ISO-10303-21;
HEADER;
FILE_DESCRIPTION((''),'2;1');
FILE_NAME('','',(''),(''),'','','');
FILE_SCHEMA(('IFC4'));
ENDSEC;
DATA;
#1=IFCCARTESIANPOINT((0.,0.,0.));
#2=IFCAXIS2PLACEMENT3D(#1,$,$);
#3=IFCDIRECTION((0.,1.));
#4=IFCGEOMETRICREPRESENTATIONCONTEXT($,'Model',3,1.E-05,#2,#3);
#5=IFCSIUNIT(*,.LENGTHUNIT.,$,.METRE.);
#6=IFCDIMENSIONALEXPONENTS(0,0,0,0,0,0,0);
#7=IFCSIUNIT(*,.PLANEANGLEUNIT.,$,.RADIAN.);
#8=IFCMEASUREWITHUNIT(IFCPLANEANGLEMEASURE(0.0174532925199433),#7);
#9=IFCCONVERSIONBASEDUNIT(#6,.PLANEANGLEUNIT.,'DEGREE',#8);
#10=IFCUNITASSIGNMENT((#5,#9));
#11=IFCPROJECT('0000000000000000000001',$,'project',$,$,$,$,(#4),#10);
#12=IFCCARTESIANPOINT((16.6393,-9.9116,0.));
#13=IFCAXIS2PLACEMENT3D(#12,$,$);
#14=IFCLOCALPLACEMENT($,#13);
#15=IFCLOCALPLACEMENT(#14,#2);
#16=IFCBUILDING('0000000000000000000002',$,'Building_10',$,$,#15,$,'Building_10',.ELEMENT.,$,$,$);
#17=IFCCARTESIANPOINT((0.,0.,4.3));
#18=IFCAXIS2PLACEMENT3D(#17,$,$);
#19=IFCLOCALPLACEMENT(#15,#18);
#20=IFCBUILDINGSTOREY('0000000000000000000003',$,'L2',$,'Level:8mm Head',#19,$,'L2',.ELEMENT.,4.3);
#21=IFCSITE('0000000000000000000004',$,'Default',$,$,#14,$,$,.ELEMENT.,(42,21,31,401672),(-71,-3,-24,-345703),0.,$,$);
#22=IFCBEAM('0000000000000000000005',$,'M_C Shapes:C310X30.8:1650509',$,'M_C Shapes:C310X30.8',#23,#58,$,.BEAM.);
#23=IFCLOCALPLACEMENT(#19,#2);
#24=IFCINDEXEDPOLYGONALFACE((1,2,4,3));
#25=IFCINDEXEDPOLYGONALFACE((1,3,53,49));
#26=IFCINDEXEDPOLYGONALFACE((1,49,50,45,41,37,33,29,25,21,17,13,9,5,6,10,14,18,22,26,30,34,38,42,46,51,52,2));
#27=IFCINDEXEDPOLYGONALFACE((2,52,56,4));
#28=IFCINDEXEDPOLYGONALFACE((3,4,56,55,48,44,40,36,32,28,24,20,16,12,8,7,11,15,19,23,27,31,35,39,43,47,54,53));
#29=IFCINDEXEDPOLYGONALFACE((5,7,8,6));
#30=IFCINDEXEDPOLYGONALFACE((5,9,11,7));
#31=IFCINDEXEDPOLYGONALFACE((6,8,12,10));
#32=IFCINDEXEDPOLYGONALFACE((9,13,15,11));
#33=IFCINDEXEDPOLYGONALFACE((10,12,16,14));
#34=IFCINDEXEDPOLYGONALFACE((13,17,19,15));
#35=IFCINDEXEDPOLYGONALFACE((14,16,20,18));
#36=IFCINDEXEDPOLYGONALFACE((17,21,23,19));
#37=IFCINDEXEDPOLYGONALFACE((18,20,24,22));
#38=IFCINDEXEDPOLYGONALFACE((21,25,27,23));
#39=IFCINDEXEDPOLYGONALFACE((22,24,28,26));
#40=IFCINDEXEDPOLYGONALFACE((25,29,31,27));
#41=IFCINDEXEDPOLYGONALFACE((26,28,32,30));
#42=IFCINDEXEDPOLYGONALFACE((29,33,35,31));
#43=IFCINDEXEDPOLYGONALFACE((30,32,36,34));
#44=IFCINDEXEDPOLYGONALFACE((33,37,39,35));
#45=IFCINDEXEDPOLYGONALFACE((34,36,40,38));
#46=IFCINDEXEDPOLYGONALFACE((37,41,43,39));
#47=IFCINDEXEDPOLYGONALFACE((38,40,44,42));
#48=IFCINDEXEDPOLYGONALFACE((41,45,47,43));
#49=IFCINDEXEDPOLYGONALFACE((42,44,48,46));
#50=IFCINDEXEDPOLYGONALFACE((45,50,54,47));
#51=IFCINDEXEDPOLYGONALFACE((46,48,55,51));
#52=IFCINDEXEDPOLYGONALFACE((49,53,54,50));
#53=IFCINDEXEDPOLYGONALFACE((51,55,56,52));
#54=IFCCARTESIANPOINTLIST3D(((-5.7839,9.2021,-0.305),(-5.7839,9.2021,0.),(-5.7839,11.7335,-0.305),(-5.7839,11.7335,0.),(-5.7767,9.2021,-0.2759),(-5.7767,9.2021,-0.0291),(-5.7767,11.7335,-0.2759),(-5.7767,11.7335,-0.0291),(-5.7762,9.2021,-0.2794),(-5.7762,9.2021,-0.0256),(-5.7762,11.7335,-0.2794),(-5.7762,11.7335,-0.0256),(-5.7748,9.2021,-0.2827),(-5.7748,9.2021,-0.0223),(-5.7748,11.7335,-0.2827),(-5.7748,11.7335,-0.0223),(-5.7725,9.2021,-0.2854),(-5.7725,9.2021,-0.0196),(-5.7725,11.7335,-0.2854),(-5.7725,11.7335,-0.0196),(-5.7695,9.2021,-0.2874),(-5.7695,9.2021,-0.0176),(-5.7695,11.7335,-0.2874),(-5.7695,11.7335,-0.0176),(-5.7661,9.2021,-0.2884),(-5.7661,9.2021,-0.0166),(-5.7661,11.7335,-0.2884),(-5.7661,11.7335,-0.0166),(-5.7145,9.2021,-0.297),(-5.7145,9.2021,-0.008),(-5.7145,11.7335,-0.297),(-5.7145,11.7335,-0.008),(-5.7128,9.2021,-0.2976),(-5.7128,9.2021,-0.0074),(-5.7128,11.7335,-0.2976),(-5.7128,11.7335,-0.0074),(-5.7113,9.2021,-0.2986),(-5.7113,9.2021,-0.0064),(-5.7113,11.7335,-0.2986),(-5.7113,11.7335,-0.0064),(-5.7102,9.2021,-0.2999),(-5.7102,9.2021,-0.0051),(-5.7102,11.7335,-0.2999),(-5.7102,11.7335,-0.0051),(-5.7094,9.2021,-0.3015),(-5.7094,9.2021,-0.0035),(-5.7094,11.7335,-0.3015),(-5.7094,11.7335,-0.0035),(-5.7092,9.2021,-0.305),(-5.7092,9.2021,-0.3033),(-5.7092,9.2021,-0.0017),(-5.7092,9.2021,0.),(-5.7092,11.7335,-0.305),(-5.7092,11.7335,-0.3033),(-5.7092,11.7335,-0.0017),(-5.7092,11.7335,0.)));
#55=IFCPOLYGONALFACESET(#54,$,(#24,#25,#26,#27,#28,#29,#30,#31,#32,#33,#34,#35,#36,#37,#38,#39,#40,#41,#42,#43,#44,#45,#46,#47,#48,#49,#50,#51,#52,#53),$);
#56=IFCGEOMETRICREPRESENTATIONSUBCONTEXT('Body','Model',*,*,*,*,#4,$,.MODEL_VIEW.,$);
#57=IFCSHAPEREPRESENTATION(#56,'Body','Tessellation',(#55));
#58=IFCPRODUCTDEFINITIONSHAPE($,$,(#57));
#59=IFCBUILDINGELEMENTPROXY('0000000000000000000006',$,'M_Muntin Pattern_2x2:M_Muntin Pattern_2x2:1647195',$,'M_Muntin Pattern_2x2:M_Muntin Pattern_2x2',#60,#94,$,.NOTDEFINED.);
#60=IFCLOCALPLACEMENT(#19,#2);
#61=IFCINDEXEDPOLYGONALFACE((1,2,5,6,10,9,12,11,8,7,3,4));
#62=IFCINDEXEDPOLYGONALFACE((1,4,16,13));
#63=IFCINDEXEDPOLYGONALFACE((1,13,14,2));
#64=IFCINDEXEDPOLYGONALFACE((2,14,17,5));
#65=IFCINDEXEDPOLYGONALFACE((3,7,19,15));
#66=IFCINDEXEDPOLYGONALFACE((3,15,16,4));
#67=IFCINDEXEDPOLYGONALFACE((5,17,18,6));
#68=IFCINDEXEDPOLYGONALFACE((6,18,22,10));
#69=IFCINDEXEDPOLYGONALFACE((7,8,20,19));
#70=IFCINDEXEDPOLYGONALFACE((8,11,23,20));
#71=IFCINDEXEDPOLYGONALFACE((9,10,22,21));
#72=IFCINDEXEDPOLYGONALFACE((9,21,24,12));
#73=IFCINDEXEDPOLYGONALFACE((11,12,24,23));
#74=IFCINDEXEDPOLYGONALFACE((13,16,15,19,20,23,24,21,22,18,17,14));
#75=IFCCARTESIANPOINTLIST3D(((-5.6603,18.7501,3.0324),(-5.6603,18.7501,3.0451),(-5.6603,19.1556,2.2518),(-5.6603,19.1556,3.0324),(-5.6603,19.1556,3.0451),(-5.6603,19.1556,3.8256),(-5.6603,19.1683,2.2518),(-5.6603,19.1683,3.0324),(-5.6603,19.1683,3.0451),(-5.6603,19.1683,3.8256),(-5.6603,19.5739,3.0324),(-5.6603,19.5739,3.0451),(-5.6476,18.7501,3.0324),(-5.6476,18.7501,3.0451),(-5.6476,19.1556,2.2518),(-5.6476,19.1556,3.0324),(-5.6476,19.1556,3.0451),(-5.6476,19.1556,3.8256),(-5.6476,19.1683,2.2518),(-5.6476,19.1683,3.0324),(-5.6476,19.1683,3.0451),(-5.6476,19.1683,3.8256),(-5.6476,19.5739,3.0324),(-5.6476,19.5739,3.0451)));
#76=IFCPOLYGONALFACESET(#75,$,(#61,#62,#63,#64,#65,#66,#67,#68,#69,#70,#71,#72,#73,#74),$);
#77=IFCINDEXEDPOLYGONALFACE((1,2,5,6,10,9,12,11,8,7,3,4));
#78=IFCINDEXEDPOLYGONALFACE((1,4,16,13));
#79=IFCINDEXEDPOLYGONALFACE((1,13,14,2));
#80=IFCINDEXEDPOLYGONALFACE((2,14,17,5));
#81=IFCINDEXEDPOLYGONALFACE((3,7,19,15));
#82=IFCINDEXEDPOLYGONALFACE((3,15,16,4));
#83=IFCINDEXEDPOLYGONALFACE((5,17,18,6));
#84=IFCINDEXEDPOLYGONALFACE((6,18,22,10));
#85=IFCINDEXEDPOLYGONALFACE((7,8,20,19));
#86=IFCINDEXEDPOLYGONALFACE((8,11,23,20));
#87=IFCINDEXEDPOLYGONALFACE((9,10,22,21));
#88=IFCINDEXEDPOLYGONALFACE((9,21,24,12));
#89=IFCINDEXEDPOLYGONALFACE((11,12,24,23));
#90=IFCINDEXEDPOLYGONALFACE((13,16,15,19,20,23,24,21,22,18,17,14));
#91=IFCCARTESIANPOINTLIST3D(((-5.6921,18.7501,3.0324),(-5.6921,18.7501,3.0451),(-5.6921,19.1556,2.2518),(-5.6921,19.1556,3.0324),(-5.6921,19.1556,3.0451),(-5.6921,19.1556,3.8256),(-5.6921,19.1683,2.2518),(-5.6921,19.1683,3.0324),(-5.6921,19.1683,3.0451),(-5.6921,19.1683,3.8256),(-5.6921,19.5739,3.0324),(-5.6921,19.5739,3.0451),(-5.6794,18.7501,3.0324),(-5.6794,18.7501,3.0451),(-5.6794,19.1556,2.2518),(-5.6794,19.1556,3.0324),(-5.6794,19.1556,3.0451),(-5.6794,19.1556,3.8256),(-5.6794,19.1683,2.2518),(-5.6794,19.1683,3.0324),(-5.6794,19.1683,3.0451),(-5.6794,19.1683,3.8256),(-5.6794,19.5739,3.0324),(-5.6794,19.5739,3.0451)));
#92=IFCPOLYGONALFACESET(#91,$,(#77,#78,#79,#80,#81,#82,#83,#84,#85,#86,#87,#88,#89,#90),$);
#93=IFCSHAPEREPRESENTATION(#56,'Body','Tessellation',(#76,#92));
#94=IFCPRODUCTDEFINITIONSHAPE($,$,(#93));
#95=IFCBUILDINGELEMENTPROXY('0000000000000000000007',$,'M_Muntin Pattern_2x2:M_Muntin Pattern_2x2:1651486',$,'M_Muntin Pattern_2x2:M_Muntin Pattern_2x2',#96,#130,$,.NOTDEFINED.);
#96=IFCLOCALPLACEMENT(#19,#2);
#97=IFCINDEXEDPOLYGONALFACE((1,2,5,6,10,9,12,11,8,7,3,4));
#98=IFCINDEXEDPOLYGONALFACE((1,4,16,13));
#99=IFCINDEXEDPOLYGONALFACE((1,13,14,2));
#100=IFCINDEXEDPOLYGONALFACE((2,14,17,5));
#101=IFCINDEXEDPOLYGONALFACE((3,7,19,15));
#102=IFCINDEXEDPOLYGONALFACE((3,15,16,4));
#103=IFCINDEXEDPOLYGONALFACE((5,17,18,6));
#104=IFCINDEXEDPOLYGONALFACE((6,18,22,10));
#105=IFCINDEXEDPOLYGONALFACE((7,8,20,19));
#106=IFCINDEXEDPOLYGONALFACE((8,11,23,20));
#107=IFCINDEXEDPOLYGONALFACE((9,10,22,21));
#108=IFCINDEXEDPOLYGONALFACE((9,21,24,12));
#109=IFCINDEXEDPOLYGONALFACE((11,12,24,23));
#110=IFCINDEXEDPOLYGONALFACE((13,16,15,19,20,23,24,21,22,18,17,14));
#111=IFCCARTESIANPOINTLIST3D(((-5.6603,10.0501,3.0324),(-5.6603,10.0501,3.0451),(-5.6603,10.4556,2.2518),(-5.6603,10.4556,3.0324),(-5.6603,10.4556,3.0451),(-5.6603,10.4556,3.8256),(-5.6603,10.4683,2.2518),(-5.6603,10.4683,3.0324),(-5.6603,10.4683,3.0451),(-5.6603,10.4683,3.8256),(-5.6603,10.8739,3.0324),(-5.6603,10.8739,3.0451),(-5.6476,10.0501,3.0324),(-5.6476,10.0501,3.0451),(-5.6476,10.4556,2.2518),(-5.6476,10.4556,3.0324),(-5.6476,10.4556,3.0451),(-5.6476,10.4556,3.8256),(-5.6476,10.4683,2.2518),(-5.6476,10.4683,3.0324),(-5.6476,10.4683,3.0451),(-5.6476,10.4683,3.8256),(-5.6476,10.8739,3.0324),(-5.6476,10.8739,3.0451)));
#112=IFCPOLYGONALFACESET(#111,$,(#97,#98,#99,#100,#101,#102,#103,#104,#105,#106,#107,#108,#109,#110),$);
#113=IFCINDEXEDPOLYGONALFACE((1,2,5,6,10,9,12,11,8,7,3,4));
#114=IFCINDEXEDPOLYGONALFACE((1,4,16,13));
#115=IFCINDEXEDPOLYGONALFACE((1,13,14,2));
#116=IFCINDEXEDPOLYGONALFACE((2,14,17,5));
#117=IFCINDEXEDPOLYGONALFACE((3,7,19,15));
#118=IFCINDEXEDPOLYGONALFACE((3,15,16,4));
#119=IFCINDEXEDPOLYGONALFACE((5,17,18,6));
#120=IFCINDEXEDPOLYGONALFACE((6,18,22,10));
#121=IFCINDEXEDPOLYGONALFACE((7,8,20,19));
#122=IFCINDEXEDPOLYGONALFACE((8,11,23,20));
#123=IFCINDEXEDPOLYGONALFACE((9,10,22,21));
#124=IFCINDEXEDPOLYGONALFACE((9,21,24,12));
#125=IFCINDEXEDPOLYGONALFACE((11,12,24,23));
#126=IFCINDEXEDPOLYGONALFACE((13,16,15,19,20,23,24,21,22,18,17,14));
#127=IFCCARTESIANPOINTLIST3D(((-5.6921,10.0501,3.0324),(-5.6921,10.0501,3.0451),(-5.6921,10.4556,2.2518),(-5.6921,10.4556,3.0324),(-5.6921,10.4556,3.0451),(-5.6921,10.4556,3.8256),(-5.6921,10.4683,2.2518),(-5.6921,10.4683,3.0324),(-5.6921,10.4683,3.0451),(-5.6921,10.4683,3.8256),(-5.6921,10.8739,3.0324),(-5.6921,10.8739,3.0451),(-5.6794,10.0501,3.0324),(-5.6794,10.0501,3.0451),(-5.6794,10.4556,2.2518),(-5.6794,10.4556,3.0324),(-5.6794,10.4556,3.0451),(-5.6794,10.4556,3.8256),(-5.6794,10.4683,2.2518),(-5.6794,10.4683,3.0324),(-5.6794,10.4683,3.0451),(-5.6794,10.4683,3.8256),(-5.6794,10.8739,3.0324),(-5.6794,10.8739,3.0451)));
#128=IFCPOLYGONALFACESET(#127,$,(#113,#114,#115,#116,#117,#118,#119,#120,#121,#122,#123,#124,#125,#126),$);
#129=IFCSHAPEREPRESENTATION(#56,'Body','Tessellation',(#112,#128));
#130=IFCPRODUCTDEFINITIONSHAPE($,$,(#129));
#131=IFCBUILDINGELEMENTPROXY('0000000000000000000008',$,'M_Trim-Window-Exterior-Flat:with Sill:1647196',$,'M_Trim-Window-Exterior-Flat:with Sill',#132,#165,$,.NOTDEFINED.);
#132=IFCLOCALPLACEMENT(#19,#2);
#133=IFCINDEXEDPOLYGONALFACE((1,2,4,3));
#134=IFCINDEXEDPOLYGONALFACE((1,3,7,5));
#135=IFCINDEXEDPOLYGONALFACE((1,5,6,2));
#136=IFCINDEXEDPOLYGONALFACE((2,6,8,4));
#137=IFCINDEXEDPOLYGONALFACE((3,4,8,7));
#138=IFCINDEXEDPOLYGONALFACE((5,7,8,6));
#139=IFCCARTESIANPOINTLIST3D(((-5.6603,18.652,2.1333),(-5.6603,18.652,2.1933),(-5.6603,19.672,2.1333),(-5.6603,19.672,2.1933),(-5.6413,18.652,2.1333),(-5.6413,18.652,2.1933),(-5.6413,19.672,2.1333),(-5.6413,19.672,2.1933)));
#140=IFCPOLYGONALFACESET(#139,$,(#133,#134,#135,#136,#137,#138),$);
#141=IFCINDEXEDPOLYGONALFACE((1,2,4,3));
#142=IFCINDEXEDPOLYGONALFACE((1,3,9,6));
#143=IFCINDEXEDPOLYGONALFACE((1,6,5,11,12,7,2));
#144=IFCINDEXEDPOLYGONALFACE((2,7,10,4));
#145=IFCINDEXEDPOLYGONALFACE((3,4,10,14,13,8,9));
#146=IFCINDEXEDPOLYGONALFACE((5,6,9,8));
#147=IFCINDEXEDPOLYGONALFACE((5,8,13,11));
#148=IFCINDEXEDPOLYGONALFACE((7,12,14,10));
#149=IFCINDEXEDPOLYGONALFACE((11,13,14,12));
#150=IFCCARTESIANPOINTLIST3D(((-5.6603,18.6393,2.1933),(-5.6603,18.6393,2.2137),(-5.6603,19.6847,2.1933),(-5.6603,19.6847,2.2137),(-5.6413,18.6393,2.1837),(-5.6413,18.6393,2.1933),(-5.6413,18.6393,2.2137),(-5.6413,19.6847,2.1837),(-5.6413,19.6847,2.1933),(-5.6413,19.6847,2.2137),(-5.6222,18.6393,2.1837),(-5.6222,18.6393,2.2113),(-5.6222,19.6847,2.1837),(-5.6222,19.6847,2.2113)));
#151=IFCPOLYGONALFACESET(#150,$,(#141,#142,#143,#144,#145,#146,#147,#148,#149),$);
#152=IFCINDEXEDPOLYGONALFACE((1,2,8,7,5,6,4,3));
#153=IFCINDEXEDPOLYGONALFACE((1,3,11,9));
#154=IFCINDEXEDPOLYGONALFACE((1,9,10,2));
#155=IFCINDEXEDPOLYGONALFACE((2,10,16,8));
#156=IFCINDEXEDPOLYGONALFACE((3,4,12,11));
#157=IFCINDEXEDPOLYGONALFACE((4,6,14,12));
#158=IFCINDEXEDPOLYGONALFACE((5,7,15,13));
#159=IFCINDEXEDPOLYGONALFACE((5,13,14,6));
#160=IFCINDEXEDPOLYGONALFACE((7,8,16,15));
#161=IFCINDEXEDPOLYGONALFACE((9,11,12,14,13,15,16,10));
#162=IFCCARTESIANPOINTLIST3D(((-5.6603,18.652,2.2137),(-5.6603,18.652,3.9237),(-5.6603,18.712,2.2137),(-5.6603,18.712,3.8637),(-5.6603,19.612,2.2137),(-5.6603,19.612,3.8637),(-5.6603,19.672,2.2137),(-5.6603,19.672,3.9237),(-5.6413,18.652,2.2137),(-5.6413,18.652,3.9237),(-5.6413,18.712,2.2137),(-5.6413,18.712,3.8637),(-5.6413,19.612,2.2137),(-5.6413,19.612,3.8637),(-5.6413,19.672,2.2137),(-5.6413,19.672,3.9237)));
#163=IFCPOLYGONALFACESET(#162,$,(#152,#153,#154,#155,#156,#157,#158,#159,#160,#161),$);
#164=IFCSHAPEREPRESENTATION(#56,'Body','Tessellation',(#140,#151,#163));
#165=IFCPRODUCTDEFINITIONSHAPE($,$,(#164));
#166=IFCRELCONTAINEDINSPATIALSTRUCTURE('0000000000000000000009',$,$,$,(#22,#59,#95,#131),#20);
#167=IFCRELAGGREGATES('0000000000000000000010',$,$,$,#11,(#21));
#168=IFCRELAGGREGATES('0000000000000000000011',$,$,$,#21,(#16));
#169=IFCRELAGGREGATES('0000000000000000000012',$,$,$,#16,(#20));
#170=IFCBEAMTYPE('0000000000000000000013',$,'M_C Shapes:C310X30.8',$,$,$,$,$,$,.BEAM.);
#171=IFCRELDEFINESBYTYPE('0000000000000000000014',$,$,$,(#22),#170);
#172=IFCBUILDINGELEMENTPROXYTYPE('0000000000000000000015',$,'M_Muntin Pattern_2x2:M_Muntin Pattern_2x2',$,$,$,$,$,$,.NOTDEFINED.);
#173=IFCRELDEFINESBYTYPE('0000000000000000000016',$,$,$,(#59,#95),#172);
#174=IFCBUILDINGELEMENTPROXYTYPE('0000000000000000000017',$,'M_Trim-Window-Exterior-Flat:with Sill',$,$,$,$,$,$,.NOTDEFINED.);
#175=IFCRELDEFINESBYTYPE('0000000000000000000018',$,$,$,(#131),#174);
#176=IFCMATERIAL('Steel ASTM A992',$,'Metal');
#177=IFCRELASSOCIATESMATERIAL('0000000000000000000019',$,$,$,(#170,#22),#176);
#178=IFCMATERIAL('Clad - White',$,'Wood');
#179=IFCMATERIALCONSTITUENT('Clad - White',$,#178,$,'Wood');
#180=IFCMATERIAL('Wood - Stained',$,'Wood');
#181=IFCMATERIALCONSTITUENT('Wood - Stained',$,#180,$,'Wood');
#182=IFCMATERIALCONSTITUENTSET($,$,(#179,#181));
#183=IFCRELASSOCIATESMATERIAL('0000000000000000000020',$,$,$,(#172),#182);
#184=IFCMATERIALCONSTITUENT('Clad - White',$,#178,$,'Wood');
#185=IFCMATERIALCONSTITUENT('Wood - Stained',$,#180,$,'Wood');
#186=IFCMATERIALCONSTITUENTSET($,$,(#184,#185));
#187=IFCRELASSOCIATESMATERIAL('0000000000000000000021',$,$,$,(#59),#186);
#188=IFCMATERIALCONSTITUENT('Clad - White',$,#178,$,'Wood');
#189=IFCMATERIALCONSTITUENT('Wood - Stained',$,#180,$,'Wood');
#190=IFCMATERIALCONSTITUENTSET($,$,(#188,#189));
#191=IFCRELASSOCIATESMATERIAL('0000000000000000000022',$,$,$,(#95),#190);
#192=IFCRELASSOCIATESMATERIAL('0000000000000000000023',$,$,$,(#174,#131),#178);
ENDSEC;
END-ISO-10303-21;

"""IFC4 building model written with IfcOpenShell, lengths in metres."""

from ifc_helpers import new_model, entity, si_unit, converted_unit, direction, frame, origin, place, context, subcontext, project, spatial, line, arc, indexed_curve, outline, extrude, source, transform, mapped, material, constituent, constituent_set, type_object, type_shapes, element, save


model = new_model("IFC4")

# Units and contexts
model_context = context("Model", 3, precision=1e-05, world=origin(), true_north=direction((0.0, 1.0)))
body_context = subcontext(model_context, "Body", "Model", "MODEL_VIEW")
ifc_project = project(units=[si_unit("LENGTHUNIT", "METRE"), converted_unit("PLANEANGLEUNIT", "DEGREE", entity("IfcPlaneAngleMeasure", 0.0174532925199433), si_unit("PLANEANGLEUNIT", "RADIAN"), dimensions=[0, 0, 0, 0, 0, 0, 0])], contexts=[model_context])

# Site, building, storey
site_placement = place(None, frame((16.6393, -9.9116, 0.0)))
site = spatial("IfcSite", under=ifc_project, at=site_placement, Name="Default", CompositionType="ELEMENT", RefLatitude=(42, 21, 31, 401672), RefLongitude=(-71, -3, -24, -345703), RefElevation=0.0)
building_placement = place(site_placement, origin())
building = spatial("IfcBuilding", under=site, at=building_placement, Name="Building_10", LongName="Building_10", CompositionType="ELEMENT")
storey_placement = place(building_placement, frame((0.0, 0.0, 4.3)))
storey = spatial("IfcBuildingStorey", under=building, at=storey_placement, Name="L2", ObjectType="Level:8mm Head", LongName="L2", CompositionType="ELEMENT", Elevation=4.3)

# Shared definitions
ifc_material_1 = material(Name="Steel ASTM A992", Category="Metal")

# Beam
beam_type_1 = type_object("IfcBeamType", Name="M_C Shapes:C310X30.8", PredefinedType="BEAM", material=ifc_material_1)
shared_shape_1 = source(origin(), body_context, "Body", "SweptSolid", [
    extrude(outline(indexed_curve([(-0.0406, -0.1525), (0.0341, -0.1525), (0.0341, -0.1508), (0.0326, -0.1467), (0.0288, -0.1445), (-0.0228, -0.1359), (-0.0305, -0.1316), (-0.0335, -0.1234), (-0.0335, 0.1234), (-0.0305, 0.1316), (-0.0228, 0.1359), (0.0288, 0.1445), (0.0326, 0.1467), (0.0341, 0.1508), (0.0341, 0.1525), (-0.0406, 0.1525)], segments=[line(1, 2, 3), arc(3, 4, 5), line(5, 6), arc(6, 7, 8), line(8, 9), arc(9, 10, 11), line(11, 12), arc(12, 13, 14), line(14, 15, 16, 1)], self_intersect=False)), frame((-1.2657, -0.0229, 0.0), z_axis=(1.0, 0.0, 0.0), x_axis=(0.0, -1.0, 0.0)), (0.0, 0.0, 1.0), 2.5314),
])
type_shapes(beam_type_1, [shared_shape_1])
for number, where, z_axis, x_axis, name in (
    (1, (-5.7662, 10.4678, -0.1525), (0.0, 0.0, 1.0), (0.0, 1.0, 0.0), "M_C Shapes:C310X30.8:1650509"),
):
    element("IfcBeam", number, at=place(storey_placement, frame(where, z_axis=z_axis, x_axis=x_axis)), inside=storey, type_object=beam_type_1, material=ifc_material_1, Name=name, ObjectType="M_C Shapes:C310X30.8", PredefinedType="BEAM", context=body_context, shape_type="MappedRepresentation", body=[
        mapped(shared_shape_1, transform((0.0, 0.0, 0.0), scale=1.0)),
    ])

# Building element proxies
ifc_material_2 = material(Name="Clad - White", Category="Wood")
ifc_constituent_1 = constituent(ifc_material_2, Name="Clad - White", Category="Wood")
ifc_material_3 = material(Name="Wood - Stained", Category="Wood")
ifc_constituent_2 = constituent(ifc_material_3, Name="Wood - Stained", Category="Wood")
ifc_constituent_set_1 = constituent_set(constituents=[ifc_constituent_1, ifc_constituent_2])
ifc_constituent_3 = constituent(ifc_material_2, Name="Clad - White", Category="Wood")
ifc_constituent_4 = constituent(ifc_material_3, Name="Wood - Stained", Category="Wood")
ifc_constituent_set_2 = constituent_set(constituents=[ifc_constituent_3, ifc_constituent_4])
building_element_proxy_type_1 = type_object("IfcBuildingElementProxyType", Name="M_Muntin Pattern_2x2:M_Muntin Pattern_2x2", PredefinedType="NOTDEFINED", material=ifc_constituent_set_2)
shared_shape_2 = source(origin(), body_context, "Body", "SweptSolid", [
    extrude(outline(indexed_curve([(0.0064, -0.0064), (0.7869, -0.0064), (0.7869, 0.0063), (0.0064, 0.0063), (0.0064, 0.4119), (-0.0063, 0.4119), (-0.0063, 0.0063), (-0.7869, 0.0063), (-0.7869, -0.0064), (-0.0063, -0.0064), (-0.0063, -0.4119), (0.0064, -0.4119), (0.0064, -0.0064)], self_intersect=False)), frame((0.0, -0.0222, 0.7869), z_axis=(0.0, 1.0, 0.0), x_axis=(0.0, 0.0, 1.0)), (0.0, 0.0, 1.0), 0.0127),
    extrude(outline(indexed_curve([(0.0064, -0.0064), (0.7869, -0.0064), (0.7869, 0.0063), (0.0064, 0.0063), (0.0064, 0.4119), (-0.0063, 0.4119), (-0.0063, 0.0063), (-0.7869, 0.0063), (-0.7869, -0.0064), (-0.0063, -0.0064), (-0.0063, -0.4119), (0.0064, -0.4119), (0.0064, -0.0064)], self_intersect=False)), frame((0.0, 0.0095, 0.7869), z_axis=(0.0, 1.0, 0.0), x_axis=(0.0, 0.0, 1.0)), (0.0, 0.0, 1.0), 0.0127),
])
type_shapes(building_element_proxy_type_1, [shared_shape_2])
proxy_1_placement = place(storey_placement, frame((-5.6698, 19.162, 2.2518), z_axis=(0.0, 0.0, 1.0), x_axis=(0.0, 1.0, 0.0)))
element("IfcBuildingElementProxy", 2, at=proxy_1_placement, inside=storey, type_object=building_element_proxy_type_1, material=ifc_constituent_set_1, Name="M_Muntin Pattern_2x2:M_Muntin Pattern_2x2:1647195", ObjectType="M_Muntin Pattern_2x2:M_Muntin Pattern_2x2", PredefinedType="NOTDEFINED", context=body_context, shape_type="MappedRepresentation", body=[
    mapped(shared_shape_2, transform((0.0, 0.0, 0.0), scale=1.0)),
])
ifc_constituent_5 = constituent(ifc_material_2, Name="Clad - White", Category="Wood")
ifc_constituent_6 = constituent(ifc_material_3, Name="Wood - Stained", Category="Wood")
ifc_constituent_set_3 = constituent_set(constituents=[ifc_constituent_5, ifc_constituent_6])
proxy_2_placement = place(storey_placement, frame((-5.6698, 10.462, 2.2518), z_axis=(0.0, 0.0, 1.0), x_axis=(0.0, 1.0, 0.0)))
element("IfcBuildingElementProxy", 3, at=proxy_2_placement, inside=storey, type_object=building_element_proxy_type_1, material=ifc_constituent_set_3, Name="M_Muntin Pattern_2x2:M_Muntin Pattern_2x2:1651486", ObjectType="M_Muntin Pattern_2x2:M_Muntin Pattern_2x2", PredefinedType="NOTDEFINED", context=body_context, shape_type="MappedRepresentation", body=[
    mapped(shared_shape_2, transform((0.0, 0.0, 0.0), scale=1.0)),
])
building_element_proxy_type_2 = type_object("IfcBuildingElementProxyType", Name="M_Trim-Window-Exterior-Flat:with Sill", PredefinedType="NOTDEFINED", material=ifc_material_2)
shared_shape_3 = source(origin(), body_context, "Body", "SweptSolid", [
    extrude(outline(indexed_curve([(-0.51, -0.03), (0.51, -0.03), (0.51, 0.03), (-0.51, 0.03), (-0.51, -0.03)], self_intersect=False)), frame((0.0, -1.7004, 0.0), z_axis=(0.0, 0.0, 1.0), x_axis=(-1.0, 0.0, 0.0)), (0.0, 0.0, 1.0), 0.0191),
    extrude(outline(indexed_curve([(-0.019, -0.0152), (0.0, -0.0152), (0.0, -0.0057), (0.019, -0.0057), (0.019, 0.0148), (0.0, 0.0148), (-0.019, 0.0123), (-0.019, -0.0152)], self_intersect=False)), frame((-0.5227, -1.6648, 0.019), z_axis=(1.0, 0.0, 0.0), x_axis=(0.0, 0.0, -1.0)), (0.0, 0.0, 1.0), 1.0454),
    extrude(outline(indexed_curve([(-0.87, -0.51), (0.84, -0.51), (0.84, -0.45), (-0.81, -0.45), (-0.81, 0.45), (0.84, 0.45), (0.84, 0.51), (-0.87, 0.51), (-0.87, -0.51)], self_intersect=False)), frame((0.0, -0.81, 0.0), z_axis=(0.0, 0.0, 1.0), x_axis=(0.0, -1.0, 0.0)), (0.0, 0.0, 1.0), 0.0191),
])
type_shapes(building_element_proxy_type_2, [shared_shape_3])
for number, where, z_axis, x_axis, name in (
    (4, (-5.6603, 19.162, 3.8637), (1.0, 0.0, 0.0), (0.0, 1.0, 0.0), "M_Trim-Window-Exterior-Flat:with Sill:1647196"),
):
    element("IfcBuildingElementProxy", number, at=place(storey_placement, frame(where, z_axis=z_axis, x_axis=x_axis)), inside=storey, type_object=building_element_proxy_type_2, material=ifc_material_2, Name=name, ObjectType="M_Trim-Window-Exterior-Flat:with Sill", PredefinedType="NOTDEFINED", context=body_context, shape_type="MappedRepresentation", body=[
        mapped(shared_shape_3, transform((0.0, 0.0, 0.0), scale=1.0)),
    ])

save(model, "model.ifc")
